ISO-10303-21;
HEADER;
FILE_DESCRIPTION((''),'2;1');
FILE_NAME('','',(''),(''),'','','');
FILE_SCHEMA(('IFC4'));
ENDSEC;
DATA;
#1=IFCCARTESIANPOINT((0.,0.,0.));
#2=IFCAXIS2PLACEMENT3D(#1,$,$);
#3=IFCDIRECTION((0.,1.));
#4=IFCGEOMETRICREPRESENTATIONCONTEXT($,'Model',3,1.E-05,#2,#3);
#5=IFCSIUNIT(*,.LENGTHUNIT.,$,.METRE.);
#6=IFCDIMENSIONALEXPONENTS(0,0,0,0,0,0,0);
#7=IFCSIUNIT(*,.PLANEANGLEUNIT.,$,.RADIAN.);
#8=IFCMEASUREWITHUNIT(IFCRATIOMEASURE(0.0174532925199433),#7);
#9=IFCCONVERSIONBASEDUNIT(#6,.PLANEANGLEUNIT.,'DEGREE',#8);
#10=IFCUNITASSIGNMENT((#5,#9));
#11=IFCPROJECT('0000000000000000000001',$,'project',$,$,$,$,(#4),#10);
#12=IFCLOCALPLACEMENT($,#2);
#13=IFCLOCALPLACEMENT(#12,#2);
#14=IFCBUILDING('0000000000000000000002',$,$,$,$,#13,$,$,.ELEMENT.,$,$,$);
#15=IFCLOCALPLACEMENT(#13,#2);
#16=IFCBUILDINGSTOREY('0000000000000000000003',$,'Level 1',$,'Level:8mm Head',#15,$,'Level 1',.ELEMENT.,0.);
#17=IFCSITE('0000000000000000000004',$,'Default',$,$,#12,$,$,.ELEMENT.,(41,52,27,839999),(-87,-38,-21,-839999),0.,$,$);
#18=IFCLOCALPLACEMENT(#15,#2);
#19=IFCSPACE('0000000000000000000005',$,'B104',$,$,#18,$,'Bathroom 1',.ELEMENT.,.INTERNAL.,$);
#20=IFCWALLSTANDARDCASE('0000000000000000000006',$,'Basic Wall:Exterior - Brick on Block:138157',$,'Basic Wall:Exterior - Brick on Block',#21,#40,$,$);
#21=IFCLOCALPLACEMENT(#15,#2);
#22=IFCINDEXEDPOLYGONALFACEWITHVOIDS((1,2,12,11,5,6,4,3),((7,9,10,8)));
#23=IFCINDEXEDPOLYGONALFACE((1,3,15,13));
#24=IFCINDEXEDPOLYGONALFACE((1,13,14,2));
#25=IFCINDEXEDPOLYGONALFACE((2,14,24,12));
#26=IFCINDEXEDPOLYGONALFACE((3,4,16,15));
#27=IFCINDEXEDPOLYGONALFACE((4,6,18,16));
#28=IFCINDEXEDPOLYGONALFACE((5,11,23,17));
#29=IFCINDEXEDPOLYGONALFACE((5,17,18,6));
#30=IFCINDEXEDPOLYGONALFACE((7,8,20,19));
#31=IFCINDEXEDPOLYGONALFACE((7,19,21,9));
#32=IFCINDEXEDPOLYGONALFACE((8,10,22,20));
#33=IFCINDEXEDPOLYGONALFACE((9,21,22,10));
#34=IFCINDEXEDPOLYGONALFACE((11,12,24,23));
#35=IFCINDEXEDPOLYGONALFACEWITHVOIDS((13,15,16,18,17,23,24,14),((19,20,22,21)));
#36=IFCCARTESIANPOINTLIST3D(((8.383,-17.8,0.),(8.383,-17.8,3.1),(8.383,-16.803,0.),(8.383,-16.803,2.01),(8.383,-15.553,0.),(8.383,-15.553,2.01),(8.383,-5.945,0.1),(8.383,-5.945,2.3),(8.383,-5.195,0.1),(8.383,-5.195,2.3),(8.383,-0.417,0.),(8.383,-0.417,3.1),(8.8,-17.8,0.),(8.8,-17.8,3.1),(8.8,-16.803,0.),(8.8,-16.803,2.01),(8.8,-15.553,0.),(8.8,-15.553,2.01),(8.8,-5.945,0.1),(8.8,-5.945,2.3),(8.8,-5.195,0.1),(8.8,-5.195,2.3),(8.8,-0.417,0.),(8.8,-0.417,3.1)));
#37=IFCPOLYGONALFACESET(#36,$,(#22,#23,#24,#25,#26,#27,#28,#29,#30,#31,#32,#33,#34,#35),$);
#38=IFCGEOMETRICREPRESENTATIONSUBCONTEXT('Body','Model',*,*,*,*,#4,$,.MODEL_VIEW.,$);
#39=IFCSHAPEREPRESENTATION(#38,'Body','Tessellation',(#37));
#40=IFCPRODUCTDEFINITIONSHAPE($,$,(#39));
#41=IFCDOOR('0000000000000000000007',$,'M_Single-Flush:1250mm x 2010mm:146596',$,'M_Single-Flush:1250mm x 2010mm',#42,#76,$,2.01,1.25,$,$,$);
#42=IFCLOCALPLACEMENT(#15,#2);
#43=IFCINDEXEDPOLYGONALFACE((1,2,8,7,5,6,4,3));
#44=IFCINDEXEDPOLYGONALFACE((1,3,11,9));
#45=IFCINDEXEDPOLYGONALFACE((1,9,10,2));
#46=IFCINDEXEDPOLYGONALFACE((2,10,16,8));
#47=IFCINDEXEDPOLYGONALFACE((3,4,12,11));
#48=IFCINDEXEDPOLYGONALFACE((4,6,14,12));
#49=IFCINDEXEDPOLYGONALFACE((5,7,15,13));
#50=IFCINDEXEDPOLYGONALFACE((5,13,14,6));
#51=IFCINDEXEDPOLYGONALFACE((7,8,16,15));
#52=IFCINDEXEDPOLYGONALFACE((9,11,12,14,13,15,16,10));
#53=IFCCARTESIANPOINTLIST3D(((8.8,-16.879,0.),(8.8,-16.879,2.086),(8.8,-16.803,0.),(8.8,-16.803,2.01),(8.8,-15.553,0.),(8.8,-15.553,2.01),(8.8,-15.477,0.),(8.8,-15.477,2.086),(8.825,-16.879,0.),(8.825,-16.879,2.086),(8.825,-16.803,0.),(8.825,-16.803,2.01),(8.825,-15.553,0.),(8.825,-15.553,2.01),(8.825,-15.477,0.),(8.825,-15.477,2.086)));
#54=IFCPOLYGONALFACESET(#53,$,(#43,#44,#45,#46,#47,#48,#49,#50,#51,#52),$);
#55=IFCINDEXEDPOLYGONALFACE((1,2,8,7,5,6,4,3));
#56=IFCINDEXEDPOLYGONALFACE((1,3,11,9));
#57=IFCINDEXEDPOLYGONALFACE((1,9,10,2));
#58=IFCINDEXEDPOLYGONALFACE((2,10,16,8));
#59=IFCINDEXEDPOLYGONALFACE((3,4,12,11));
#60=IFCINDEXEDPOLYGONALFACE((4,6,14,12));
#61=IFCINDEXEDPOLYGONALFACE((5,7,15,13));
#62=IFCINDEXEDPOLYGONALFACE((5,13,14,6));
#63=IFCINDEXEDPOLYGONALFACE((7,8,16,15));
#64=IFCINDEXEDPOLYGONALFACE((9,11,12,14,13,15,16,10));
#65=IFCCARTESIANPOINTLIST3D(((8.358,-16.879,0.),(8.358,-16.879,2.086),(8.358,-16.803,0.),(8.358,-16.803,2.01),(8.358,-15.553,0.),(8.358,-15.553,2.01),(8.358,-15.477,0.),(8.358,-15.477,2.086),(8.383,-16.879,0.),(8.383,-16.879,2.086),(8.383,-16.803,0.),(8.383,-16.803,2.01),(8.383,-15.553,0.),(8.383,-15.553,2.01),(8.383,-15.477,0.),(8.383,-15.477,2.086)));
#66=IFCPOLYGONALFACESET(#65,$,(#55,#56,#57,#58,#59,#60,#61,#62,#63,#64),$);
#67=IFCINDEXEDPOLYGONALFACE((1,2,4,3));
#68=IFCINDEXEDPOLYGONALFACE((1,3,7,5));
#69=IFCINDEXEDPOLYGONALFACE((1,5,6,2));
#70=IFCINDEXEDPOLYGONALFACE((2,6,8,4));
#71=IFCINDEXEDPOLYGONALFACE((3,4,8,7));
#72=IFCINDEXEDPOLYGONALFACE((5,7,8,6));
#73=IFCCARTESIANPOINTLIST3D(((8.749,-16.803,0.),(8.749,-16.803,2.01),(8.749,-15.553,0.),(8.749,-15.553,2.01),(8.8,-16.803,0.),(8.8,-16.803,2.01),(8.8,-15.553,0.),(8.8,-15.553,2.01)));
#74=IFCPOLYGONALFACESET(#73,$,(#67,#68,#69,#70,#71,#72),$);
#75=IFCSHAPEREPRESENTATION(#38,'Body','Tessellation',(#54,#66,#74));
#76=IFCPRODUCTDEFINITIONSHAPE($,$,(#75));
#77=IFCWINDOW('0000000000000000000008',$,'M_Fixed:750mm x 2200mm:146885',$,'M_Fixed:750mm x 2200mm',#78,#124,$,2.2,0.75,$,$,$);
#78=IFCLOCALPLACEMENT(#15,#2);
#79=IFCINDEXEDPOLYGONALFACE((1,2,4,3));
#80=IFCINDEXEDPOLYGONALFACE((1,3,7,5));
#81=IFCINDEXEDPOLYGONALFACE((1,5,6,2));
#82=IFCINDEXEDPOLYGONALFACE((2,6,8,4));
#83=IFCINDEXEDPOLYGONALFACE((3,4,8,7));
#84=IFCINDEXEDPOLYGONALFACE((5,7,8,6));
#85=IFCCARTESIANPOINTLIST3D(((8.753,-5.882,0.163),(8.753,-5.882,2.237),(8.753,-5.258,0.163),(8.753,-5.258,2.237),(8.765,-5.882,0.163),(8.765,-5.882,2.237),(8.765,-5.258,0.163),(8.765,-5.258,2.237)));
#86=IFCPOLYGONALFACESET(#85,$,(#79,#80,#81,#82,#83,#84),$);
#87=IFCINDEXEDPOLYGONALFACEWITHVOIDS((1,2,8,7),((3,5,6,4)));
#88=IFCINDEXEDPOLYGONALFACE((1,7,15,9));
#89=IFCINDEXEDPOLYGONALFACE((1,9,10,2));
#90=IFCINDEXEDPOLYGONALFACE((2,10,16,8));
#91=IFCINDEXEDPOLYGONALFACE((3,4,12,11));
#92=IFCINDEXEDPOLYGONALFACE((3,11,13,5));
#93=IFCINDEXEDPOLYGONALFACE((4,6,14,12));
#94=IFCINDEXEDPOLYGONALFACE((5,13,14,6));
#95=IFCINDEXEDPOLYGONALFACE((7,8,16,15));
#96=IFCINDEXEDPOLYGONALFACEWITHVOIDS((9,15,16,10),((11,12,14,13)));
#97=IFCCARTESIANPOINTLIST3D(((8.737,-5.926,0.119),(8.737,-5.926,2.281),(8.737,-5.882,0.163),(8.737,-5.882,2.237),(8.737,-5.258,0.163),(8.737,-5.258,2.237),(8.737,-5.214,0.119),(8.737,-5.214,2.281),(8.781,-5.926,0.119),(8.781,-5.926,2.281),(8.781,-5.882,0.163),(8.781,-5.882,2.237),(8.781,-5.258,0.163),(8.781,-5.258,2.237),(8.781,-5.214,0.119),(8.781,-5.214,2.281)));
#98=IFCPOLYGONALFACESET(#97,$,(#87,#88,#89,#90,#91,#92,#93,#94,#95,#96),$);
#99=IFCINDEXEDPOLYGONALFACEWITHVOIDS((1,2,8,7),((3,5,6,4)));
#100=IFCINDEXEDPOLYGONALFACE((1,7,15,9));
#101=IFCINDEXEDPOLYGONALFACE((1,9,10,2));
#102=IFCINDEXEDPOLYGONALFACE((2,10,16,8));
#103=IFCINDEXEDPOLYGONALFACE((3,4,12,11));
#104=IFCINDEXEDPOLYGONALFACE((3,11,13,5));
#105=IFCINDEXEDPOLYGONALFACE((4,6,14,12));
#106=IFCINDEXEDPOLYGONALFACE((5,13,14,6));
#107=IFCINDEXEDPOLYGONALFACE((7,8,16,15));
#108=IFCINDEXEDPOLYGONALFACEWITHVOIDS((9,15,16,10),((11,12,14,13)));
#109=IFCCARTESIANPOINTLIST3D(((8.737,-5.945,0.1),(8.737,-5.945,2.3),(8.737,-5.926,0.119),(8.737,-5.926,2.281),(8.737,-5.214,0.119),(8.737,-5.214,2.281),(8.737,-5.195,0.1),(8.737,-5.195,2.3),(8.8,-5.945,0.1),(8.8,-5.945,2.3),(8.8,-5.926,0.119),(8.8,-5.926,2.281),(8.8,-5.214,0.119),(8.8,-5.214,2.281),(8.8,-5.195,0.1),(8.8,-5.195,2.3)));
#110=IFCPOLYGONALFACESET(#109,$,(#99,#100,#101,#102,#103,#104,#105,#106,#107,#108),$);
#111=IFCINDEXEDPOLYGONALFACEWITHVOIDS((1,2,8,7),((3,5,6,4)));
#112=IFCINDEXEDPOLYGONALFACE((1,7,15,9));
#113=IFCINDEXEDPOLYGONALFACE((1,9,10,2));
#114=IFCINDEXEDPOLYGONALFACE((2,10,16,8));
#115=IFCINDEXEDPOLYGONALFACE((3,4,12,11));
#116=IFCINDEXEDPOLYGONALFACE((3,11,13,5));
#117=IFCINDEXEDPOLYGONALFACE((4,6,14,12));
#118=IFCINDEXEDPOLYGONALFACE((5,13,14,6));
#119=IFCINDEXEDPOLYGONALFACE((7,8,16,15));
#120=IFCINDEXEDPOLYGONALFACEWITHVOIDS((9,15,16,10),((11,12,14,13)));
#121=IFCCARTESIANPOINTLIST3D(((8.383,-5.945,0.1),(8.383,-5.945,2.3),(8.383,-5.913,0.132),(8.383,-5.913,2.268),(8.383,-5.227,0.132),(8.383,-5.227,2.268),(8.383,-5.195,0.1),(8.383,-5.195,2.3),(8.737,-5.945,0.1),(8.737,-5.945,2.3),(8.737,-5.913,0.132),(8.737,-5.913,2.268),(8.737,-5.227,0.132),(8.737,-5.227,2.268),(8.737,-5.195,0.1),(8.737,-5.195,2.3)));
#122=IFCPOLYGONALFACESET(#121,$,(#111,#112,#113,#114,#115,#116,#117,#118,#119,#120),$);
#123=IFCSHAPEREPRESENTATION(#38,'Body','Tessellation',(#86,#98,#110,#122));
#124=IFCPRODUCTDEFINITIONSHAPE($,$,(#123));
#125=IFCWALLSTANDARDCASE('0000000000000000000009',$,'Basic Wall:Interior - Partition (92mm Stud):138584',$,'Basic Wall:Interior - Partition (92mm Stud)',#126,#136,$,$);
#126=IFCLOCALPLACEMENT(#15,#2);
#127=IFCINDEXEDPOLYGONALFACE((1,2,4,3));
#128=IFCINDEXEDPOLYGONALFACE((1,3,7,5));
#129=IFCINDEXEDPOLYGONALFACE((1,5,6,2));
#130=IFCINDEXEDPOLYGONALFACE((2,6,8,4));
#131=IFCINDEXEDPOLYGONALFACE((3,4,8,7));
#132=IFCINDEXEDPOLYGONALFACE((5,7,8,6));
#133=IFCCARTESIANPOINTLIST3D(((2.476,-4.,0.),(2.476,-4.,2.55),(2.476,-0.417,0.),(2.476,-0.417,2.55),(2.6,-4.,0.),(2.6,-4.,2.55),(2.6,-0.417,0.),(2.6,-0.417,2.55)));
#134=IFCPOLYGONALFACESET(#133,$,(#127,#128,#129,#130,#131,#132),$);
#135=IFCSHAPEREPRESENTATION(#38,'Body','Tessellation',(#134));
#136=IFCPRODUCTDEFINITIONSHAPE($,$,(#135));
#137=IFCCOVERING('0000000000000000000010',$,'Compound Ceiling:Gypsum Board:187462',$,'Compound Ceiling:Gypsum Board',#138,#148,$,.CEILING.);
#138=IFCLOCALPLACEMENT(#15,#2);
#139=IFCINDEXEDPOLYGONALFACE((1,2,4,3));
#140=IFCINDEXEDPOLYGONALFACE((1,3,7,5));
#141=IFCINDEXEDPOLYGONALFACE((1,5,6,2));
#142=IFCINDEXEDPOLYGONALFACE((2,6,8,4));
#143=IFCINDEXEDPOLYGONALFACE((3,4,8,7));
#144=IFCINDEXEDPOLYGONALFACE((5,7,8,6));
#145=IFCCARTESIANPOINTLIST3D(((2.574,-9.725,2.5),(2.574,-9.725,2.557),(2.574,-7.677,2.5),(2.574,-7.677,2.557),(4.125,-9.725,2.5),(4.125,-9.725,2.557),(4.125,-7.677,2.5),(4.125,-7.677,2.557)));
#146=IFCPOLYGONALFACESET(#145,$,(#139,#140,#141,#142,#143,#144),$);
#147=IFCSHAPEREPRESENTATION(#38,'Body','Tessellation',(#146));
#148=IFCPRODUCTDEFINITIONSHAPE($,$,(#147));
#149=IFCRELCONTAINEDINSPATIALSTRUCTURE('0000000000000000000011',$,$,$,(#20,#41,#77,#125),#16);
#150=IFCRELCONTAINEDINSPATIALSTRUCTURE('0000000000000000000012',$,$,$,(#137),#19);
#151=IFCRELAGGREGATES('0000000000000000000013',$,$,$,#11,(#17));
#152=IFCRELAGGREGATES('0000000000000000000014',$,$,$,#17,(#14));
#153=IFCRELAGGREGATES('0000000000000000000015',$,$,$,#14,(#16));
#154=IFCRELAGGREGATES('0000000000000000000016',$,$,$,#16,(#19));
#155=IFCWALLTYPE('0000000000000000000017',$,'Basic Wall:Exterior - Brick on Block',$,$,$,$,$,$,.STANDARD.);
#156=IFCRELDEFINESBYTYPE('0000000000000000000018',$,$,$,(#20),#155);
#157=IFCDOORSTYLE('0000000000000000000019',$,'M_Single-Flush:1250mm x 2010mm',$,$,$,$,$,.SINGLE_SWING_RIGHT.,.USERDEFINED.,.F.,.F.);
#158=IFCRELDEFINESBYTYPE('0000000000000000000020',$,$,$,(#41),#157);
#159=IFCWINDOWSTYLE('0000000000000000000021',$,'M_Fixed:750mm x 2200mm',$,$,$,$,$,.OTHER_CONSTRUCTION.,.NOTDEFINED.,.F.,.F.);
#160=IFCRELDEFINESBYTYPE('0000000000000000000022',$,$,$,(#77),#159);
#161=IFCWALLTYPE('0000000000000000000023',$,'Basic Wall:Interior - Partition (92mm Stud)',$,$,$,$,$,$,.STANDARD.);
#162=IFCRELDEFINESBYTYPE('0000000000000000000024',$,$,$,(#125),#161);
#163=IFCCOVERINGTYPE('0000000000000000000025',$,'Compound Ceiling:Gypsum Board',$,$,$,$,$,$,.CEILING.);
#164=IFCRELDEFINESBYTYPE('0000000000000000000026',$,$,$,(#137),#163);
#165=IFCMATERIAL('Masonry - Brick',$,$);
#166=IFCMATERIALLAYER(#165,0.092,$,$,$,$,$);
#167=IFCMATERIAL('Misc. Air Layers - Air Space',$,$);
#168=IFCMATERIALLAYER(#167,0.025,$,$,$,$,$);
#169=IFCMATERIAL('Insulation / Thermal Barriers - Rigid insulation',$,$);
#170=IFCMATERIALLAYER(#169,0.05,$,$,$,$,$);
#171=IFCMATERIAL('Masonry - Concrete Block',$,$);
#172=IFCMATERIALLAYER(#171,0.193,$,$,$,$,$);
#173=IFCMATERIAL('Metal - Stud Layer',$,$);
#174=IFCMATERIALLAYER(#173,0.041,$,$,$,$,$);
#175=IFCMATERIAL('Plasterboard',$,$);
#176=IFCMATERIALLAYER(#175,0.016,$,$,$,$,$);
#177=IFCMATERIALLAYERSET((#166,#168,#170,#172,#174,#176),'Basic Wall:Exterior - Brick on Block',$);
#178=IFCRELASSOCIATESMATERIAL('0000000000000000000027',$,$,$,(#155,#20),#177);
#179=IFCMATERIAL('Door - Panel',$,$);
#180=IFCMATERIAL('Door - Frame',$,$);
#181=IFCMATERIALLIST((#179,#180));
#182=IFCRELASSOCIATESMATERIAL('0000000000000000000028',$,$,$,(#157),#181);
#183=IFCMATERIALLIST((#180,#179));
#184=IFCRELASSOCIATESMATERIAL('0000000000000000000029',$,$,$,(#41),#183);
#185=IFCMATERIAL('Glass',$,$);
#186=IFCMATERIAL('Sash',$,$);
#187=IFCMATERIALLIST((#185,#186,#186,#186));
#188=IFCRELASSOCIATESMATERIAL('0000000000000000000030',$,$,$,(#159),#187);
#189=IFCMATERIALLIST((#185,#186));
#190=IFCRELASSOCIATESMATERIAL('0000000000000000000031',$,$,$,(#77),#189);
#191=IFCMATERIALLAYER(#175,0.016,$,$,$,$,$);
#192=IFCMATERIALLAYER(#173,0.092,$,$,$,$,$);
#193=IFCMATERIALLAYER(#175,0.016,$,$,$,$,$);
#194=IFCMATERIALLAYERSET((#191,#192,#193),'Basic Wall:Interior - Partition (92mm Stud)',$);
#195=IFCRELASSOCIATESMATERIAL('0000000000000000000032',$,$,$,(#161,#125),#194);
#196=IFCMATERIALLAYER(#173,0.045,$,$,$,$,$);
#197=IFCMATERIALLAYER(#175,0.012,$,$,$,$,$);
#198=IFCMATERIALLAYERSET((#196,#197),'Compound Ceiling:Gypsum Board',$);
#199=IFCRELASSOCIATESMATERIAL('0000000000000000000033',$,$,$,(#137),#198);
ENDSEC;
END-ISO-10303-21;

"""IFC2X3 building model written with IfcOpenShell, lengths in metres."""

from ifc_helpers import new_model, entity, si_unit, converted_unit, direction, frame, frame_2d, origin, origin_2d_with_axis, place, context, subcontext, project, spatial, polyline, rectangle, outline, extrude, source, transform, mapped, material, material_list, layer, layer_set, layer_usage, type_object, type_shapes, element, fill, save


model = new_model("IFC2X3")

# Units and contexts
model_context = context("Model", 3, precision=1e-05, world=origin(), true_north=direction((0.0, 1.0)))
body_context = subcontext(model_context, "Body", "Model", "MODEL_VIEW")
ifc_project = project(units=[si_unit("LENGTHUNIT", "METRE"), converted_unit("PLANEANGLEUNIT", "DEGREE", entity("IfcRatioMeasure", 0.0174532925199433), si_unit("PLANEANGLEUNIT", "RADIAN"), dimensions=[0, 0, 0, 0, 0, 0, 0])], contexts=[model_context])

# Site, building, storey
site_placement = place(None, origin())
site = spatial("IfcSite", under=ifc_project, at=site_placement, Name="Default", CompositionType="ELEMENT", RefLatitude=(41, 52, 27, 839999), RefLongitude=(-87, -38, -21, -839999), RefElevation=0.0)
building_placement = place(site_placement, origin())
building = spatial("IfcBuilding", under=site, at=building_placement, CompositionType="ELEMENT")
storey_placement = place(building_placement, origin())
storey = spatial("IfcBuildingStorey", under=building, at=storey_placement, Name="Level 1", ObjectType="Level:8mm Head", LongName="Level 1", CompositionType="ELEMENT", Elevation=0.0)

# Shared definitions
ifc_material_1 = material(Name="Masonry - Brick")
ifc_layer_1 = layer(ifc_material_1, 0.092)
ifc_material_2 = material(Name="Misc. Air Layers - Air Space")
ifc_layer_2 = layer(ifc_material_2, 0.025)
ifc_material_3 = material(Name="Insulation / Thermal Barriers - Rigid insulation")
ifc_layer_3 = layer(ifc_material_3, 0.05)
ifc_material_4 = material(Name="Masonry - Concrete Block")
ifc_layer_4 = layer(ifc_material_4, 0.193)
ifc_material_5 = material(Name="Metal - Stud Layer")
ifc_layer_5 = layer(ifc_material_5, 0.041)
ifc_material_6 = material(Name="Plasterboard")
ifc_layer_6 = layer(ifc_material_6, 0.016)
ifc_layer_set_1 = layer_set([ifc_layer_1, ifc_layer_2, ifc_layer_3, ifc_layer_4, ifc_layer_5, ifc_layer_6], Name="Basic Wall:Exterior - Brick on Block")
wall_type_1 = type_object("IfcWallType", Name="Basic Wall:Exterior - Brick on Block", PredefinedType="STANDARD", material=ifc_layer_set_1)
ifc_material_7 = material(Name="Glass")
ifc_material_8 = material(Name="Sash")
ifc_material_9 = material(Name="Door - Frame")
ifc_material_10 = material(Name="Door - Panel")

# Wall, openings, door, window
ifc_layer_usage_1 = layer_usage(ifc_layer_set_1, "AXIS2", "NEGATIVE", 0.2085)
wall_1_placement = place(storey_placement, frame((8.5915, -0.417, 0.0), z_axis=(0.0, 0.0, 1.0), x_axis=(0.0, -1.0, 0.0)))
wall_1 = element("IfcWallStandardCase", 1, at=wall_1_placement, inside=storey, type_object=wall_type_1, material=ifc_layer_usage_1, Name="Basic Wall:Exterior - Brick on Block:138157", ObjectType="Basic Wall:Exterior - Brick on Block", context=body_context, shape_type="SweptSolid", body=[
    extrude(rectangle(XDim=17.383, YDim=0.417, at=frame_2d((8.6915, 0.0), x_axis=(-1.0, 0.0))), origin(), (0.0, 0.0, 1.0), 3.1),
])
opening_1_placement = place(wall_1_placement, frame((15.136, -0.2085, 0.0)))
opening_1 = element("IfcOpeningElement", 2, at=opening_1_placement, cuts=wall_1, ObjectType="Opening", context=body_context, shape_type="SweptSolid", body=[
    extrude(rectangle(XDim=1.25, YDim=2.01, at=frame_2d((1.005, 0.625), x_axis=(0.0, 1.0))), frame((0.0, 0.0, 0.0), z_axis=(0.0, 1.0, 0.0), x_axis=(0.0, 0.0, 1.0)), (0.0, 0.0, 1.0), 0.417),
])
opening_2_placement = place(wall_1_placement, frame((4.778, -0.2085, 0.1)))
opening_2 = element("IfcOpeningElement", 3, at=opening_2_placement, cuts=wall_1, ObjectType="Opening", context=body_context, shape_type="SweptSolid", body=[
    extrude(rectangle(XDim=2.2, YDim=0.75, at=frame_2d((1.1, 0.375), x_axis=(1.0, 0.0))), frame((0.0, 0.0, 0.0), z_axis=(0.0, 1.0, 0.0), x_axis=(0.0, 0.0, 1.0)), (0.0, 0.0, 1.0), 0.417),
])
ifc_material_list_1 = material_list([ifc_material_9, ifc_material_10])
ifc_material_list_2 = material_list([ifc_material_10, ifc_material_9])
door_style_1 = type_object("IfcDoorStyle", Name="M_Single-Flush:1250mm x 2010mm", ConstructionType="USERDEFINED", OperationType="SINGLE_SWING_RIGHT", ParameterTakesPrecedence=False, Sizeable=False, material=ifc_material_list_2)
shared_shape_1 = source(origin(), body_context, "Body", "SweptSolid", [
    extrude(outline(polyline([(-0.701, -1.062), (0.701, -1.062), (0.701, 1.024), (0.625, 1.024), (0.625, -0.986), (-0.625, -0.986), (-0.625, 1.024), (-0.701, 1.024), (-0.701, -1.062)])), frame((0.625, 0.417, 1.024), z_axis=(0.0, 1.0, 0.0), x_axis=(1.0, 0.0, 0.0)), (0.0, 0.0, 1.0), 0.025),
    extrude(outline(polyline([(-1.062, -0.701), (1.024, -0.701), (1.024, -0.625), (-0.986, -0.625), (-0.986, 0.625), (1.024, 0.625), (1.024, 0.701), (-1.062, 0.701), (-1.062, -0.701)])), frame((0.625, -0.025, 1.024), z_axis=(0.0, 1.0, 0.0), x_axis=(0.0, 0.0, -1.0)), (0.0, 0.0, 1.0), 0.025),
    extrude(rectangle(XDim=0.051, YDim=1.25, at=frame_2d((0.0, 0.0), x_axis=(1.0, 0.0))), frame((0.625, 0.3915, 0.0), z_axis=(0.0, 0.0, 1.0), x_axis=(0.0, 1.0, 0.0)), (0.0, 0.0, 1.0), 2.01),
])
type_shapes(door_style_1, [shared_shape_1])
door_1_placement = place(opening_1_placement, origin())
door_1 = element("IfcDoor", 4, at=door_1_placement, inside=storey, type_object=door_style_1, material=ifc_material_list_1, Name="M_Single-Flush:1250mm x 2010mm:146596", ObjectType="M_Single-Flush:1250mm x 2010mm", OverallHeight=2.01, OverallWidth=1.25, context=body_context, shape_type="MappedRepresentation", body=[
    mapped(shared_shape_1, transform((0.0, 0.0, 0.0), scale=1.0)),
])
fill(opening_1, door_1)
ifc_material_list_3 = material_list([ifc_material_7, ifc_material_8])
ifc_material_list_4 = material_list([ifc_material_7, ifc_material_8, ifc_material_8, ifc_material_8])
window_style_1 = type_object("IfcWindowStyle", Name="M_Fixed:750mm x 2200mm", ConstructionType="OTHER_CONSTRUCTION", OperationType="NOTDEFINED", ParameterTakesPrecedence=False, Sizeable=False, material=ifc_material_list_4)
shared_shape_2 = source(origin(), body_context, "Body", "SweptSolid", [
    extrude(rectangle(XDim=0.012, YDim=0.624, at=origin_2d_with_axis()), frame((0.375, 0.376, 0.063), z_axis=(0.0, 0.0, 1.0), x_axis=(0.0, -1.0, 0.0)), (0.0, 0.0, 1.0), 2.074),
    extrude(outline(polyline([(-0.356, -1.081), (0.356, -1.081), (0.356, 1.081), (-0.356, 1.081), (-0.356, -1.081)]), holes=[polyline([(-0.312, -1.037), (-0.312, 1.037), (0.312, 1.037), (0.312, -1.037), (-0.312, -1.037)])]), frame((0.375, 0.354, 1.1), z_axis=(0.0, 1.0, 0.0), x_axis=(1.0, 0.0, 0.0)), (0.0, 0.0, 1.0), 0.044),
    extrude(outline(polyline([(-0.375, -1.1), (0.375, -1.1), (0.375, 1.1), (-0.375, 1.1), (-0.375, -1.1)]), holes=[polyline([(-0.356, -1.081), (-0.356, 1.081), (0.356, 1.081), (0.356, -1.081), (-0.356, -1.081)])]), frame((0.375, 0.354, 1.1), z_axis=(0.0, 1.0, 0.0), x_axis=(1.0, 0.0, 0.0)), (0.0, 0.0, 1.0), 0.063),
    extrude(outline(polyline([(-0.375, -1.1), (0.375, -1.1), (0.375, 1.1), (-0.375, 1.1), (-0.375, -1.1)]), holes=[polyline([(-0.343, -1.068), (-0.343, 1.068), (0.343, 1.068), (0.343, -1.068), (-0.343, -1.068)])]), frame((0.375, 0.0, 1.1), z_axis=(0.0, 1.0, 0.0), x_axis=(1.0, 0.0, 0.0)), (0.0, 0.0, 1.0), 0.354),
])
type_shapes(window_style_1, [shared_shape_2])
window_1_placement = place(opening_2_placement, origin())
window_1 = element("IfcWindow", 5, at=window_1_placement, inside=storey, type_object=window_style_1, material=ifc_material_list_3, Name="M_Fixed:750mm x 2200mm:146885", ObjectType="M_Fixed:750mm x 2200mm", OverallHeight=2.2, OverallWidth=0.75, context=body_context, shape_type="MappedRepresentation", body=[
    mapped(shared_shape_2, transform((0.0, 0.0, 0.0), scale=1.0)),
])
fill(opening_2, window_1)

# Wall
ifc_layer_7 = layer(ifc_material_6, 0.016)
ifc_layer_8 = layer(ifc_material_5, 0.092)
ifc_layer_9 = layer(ifc_material_6, 0.016)
ifc_layer_set_2 = layer_set([ifc_layer_7, ifc_layer_8, ifc_layer_9], Name="Basic Wall:Interior - Partition (92mm Stud)")
ifc_layer_usage_2 = layer_usage(ifc_layer_set_2, "AXIS2", "NEGATIVE", 0.062)
wall_type_2 = type_object("IfcWallType", Name="Basic Wall:Interior - Partition (92mm Stud)", PredefinedType="STANDARD", material=ifc_layer_set_2)
wall_2_placement = place(storey_placement, frame((2.538, -0.417, 0.0), z_axis=(0.0, 0.0, 1.0), x_axis=(0.0, -1.0, 0.0)))
element("IfcWallStandardCase", 6, at=wall_2_placement, inside=storey, type_object=wall_type_2, material=ifc_layer_usage_2, Name="Basic Wall:Interior - Partition (92mm Stud):138584", ObjectType="Basic Wall:Interior - Partition (92mm Stud)", context=body_context, shape_type="SweptSolid", body=[
    extrude(rectangle(XDim=3.583, YDim=0.124, at=frame_2d((1.7915, 0.0), x_axis=(-1.0, 0.0))), origin(), (0.0, 0.0, 1.0), 2.55),
])

# Shared definitions
ifc_layer_10 = layer(ifc_material_5, 0.045)
ifc_layer_11 = layer(ifc_material_6, 0.012)
ifc_layer_set_3 = layer_set([ifc_layer_10, ifc_layer_11], Name="Compound Ceiling:Gypsum Board")

# Shared definitions
space_1_placement = place(storey_placement, origin())
space_1 = spatial("IfcSpace", under=storey, at=space_1_placement, Name="B104", LongName="Bathroom 1", CompositionType="ELEMENT", InteriorOrExteriorSpace="INTERNAL")

# Covering
ifc_layer_usage_3 = layer_usage(ifc_layer_set_3, "AXIS3", "POSITIVE", 0.0)
covering_type_1 = type_object("IfcCoveringType", Name="Compound Ceiling:Gypsum Board", PredefinedType="CEILING")
covering_1_placement = place(space_1_placement, origin())
element("IfcCovering", 7, at=covering_1_placement, inside=space_1, type_object=covering_type_1, material=ifc_layer_usage_3, Name="Compound Ceiling:Gypsum Board:187462", ObjectType="Compound Ceiling:Gypsum Board", PredefinedType="CEILING", context=body_context, shape_type="SweptSolid", body=[
    extrude(rectangle(XDim=1.551, YDim=2.048, at=frame_2d((0.0, 0.0), x_axis=(1.0, 0.0))), frame((3.3495, -8.701, 2.5)), (0.0, 0.0, 1.0), 0.057),
])

save(model, "model.ifc")
